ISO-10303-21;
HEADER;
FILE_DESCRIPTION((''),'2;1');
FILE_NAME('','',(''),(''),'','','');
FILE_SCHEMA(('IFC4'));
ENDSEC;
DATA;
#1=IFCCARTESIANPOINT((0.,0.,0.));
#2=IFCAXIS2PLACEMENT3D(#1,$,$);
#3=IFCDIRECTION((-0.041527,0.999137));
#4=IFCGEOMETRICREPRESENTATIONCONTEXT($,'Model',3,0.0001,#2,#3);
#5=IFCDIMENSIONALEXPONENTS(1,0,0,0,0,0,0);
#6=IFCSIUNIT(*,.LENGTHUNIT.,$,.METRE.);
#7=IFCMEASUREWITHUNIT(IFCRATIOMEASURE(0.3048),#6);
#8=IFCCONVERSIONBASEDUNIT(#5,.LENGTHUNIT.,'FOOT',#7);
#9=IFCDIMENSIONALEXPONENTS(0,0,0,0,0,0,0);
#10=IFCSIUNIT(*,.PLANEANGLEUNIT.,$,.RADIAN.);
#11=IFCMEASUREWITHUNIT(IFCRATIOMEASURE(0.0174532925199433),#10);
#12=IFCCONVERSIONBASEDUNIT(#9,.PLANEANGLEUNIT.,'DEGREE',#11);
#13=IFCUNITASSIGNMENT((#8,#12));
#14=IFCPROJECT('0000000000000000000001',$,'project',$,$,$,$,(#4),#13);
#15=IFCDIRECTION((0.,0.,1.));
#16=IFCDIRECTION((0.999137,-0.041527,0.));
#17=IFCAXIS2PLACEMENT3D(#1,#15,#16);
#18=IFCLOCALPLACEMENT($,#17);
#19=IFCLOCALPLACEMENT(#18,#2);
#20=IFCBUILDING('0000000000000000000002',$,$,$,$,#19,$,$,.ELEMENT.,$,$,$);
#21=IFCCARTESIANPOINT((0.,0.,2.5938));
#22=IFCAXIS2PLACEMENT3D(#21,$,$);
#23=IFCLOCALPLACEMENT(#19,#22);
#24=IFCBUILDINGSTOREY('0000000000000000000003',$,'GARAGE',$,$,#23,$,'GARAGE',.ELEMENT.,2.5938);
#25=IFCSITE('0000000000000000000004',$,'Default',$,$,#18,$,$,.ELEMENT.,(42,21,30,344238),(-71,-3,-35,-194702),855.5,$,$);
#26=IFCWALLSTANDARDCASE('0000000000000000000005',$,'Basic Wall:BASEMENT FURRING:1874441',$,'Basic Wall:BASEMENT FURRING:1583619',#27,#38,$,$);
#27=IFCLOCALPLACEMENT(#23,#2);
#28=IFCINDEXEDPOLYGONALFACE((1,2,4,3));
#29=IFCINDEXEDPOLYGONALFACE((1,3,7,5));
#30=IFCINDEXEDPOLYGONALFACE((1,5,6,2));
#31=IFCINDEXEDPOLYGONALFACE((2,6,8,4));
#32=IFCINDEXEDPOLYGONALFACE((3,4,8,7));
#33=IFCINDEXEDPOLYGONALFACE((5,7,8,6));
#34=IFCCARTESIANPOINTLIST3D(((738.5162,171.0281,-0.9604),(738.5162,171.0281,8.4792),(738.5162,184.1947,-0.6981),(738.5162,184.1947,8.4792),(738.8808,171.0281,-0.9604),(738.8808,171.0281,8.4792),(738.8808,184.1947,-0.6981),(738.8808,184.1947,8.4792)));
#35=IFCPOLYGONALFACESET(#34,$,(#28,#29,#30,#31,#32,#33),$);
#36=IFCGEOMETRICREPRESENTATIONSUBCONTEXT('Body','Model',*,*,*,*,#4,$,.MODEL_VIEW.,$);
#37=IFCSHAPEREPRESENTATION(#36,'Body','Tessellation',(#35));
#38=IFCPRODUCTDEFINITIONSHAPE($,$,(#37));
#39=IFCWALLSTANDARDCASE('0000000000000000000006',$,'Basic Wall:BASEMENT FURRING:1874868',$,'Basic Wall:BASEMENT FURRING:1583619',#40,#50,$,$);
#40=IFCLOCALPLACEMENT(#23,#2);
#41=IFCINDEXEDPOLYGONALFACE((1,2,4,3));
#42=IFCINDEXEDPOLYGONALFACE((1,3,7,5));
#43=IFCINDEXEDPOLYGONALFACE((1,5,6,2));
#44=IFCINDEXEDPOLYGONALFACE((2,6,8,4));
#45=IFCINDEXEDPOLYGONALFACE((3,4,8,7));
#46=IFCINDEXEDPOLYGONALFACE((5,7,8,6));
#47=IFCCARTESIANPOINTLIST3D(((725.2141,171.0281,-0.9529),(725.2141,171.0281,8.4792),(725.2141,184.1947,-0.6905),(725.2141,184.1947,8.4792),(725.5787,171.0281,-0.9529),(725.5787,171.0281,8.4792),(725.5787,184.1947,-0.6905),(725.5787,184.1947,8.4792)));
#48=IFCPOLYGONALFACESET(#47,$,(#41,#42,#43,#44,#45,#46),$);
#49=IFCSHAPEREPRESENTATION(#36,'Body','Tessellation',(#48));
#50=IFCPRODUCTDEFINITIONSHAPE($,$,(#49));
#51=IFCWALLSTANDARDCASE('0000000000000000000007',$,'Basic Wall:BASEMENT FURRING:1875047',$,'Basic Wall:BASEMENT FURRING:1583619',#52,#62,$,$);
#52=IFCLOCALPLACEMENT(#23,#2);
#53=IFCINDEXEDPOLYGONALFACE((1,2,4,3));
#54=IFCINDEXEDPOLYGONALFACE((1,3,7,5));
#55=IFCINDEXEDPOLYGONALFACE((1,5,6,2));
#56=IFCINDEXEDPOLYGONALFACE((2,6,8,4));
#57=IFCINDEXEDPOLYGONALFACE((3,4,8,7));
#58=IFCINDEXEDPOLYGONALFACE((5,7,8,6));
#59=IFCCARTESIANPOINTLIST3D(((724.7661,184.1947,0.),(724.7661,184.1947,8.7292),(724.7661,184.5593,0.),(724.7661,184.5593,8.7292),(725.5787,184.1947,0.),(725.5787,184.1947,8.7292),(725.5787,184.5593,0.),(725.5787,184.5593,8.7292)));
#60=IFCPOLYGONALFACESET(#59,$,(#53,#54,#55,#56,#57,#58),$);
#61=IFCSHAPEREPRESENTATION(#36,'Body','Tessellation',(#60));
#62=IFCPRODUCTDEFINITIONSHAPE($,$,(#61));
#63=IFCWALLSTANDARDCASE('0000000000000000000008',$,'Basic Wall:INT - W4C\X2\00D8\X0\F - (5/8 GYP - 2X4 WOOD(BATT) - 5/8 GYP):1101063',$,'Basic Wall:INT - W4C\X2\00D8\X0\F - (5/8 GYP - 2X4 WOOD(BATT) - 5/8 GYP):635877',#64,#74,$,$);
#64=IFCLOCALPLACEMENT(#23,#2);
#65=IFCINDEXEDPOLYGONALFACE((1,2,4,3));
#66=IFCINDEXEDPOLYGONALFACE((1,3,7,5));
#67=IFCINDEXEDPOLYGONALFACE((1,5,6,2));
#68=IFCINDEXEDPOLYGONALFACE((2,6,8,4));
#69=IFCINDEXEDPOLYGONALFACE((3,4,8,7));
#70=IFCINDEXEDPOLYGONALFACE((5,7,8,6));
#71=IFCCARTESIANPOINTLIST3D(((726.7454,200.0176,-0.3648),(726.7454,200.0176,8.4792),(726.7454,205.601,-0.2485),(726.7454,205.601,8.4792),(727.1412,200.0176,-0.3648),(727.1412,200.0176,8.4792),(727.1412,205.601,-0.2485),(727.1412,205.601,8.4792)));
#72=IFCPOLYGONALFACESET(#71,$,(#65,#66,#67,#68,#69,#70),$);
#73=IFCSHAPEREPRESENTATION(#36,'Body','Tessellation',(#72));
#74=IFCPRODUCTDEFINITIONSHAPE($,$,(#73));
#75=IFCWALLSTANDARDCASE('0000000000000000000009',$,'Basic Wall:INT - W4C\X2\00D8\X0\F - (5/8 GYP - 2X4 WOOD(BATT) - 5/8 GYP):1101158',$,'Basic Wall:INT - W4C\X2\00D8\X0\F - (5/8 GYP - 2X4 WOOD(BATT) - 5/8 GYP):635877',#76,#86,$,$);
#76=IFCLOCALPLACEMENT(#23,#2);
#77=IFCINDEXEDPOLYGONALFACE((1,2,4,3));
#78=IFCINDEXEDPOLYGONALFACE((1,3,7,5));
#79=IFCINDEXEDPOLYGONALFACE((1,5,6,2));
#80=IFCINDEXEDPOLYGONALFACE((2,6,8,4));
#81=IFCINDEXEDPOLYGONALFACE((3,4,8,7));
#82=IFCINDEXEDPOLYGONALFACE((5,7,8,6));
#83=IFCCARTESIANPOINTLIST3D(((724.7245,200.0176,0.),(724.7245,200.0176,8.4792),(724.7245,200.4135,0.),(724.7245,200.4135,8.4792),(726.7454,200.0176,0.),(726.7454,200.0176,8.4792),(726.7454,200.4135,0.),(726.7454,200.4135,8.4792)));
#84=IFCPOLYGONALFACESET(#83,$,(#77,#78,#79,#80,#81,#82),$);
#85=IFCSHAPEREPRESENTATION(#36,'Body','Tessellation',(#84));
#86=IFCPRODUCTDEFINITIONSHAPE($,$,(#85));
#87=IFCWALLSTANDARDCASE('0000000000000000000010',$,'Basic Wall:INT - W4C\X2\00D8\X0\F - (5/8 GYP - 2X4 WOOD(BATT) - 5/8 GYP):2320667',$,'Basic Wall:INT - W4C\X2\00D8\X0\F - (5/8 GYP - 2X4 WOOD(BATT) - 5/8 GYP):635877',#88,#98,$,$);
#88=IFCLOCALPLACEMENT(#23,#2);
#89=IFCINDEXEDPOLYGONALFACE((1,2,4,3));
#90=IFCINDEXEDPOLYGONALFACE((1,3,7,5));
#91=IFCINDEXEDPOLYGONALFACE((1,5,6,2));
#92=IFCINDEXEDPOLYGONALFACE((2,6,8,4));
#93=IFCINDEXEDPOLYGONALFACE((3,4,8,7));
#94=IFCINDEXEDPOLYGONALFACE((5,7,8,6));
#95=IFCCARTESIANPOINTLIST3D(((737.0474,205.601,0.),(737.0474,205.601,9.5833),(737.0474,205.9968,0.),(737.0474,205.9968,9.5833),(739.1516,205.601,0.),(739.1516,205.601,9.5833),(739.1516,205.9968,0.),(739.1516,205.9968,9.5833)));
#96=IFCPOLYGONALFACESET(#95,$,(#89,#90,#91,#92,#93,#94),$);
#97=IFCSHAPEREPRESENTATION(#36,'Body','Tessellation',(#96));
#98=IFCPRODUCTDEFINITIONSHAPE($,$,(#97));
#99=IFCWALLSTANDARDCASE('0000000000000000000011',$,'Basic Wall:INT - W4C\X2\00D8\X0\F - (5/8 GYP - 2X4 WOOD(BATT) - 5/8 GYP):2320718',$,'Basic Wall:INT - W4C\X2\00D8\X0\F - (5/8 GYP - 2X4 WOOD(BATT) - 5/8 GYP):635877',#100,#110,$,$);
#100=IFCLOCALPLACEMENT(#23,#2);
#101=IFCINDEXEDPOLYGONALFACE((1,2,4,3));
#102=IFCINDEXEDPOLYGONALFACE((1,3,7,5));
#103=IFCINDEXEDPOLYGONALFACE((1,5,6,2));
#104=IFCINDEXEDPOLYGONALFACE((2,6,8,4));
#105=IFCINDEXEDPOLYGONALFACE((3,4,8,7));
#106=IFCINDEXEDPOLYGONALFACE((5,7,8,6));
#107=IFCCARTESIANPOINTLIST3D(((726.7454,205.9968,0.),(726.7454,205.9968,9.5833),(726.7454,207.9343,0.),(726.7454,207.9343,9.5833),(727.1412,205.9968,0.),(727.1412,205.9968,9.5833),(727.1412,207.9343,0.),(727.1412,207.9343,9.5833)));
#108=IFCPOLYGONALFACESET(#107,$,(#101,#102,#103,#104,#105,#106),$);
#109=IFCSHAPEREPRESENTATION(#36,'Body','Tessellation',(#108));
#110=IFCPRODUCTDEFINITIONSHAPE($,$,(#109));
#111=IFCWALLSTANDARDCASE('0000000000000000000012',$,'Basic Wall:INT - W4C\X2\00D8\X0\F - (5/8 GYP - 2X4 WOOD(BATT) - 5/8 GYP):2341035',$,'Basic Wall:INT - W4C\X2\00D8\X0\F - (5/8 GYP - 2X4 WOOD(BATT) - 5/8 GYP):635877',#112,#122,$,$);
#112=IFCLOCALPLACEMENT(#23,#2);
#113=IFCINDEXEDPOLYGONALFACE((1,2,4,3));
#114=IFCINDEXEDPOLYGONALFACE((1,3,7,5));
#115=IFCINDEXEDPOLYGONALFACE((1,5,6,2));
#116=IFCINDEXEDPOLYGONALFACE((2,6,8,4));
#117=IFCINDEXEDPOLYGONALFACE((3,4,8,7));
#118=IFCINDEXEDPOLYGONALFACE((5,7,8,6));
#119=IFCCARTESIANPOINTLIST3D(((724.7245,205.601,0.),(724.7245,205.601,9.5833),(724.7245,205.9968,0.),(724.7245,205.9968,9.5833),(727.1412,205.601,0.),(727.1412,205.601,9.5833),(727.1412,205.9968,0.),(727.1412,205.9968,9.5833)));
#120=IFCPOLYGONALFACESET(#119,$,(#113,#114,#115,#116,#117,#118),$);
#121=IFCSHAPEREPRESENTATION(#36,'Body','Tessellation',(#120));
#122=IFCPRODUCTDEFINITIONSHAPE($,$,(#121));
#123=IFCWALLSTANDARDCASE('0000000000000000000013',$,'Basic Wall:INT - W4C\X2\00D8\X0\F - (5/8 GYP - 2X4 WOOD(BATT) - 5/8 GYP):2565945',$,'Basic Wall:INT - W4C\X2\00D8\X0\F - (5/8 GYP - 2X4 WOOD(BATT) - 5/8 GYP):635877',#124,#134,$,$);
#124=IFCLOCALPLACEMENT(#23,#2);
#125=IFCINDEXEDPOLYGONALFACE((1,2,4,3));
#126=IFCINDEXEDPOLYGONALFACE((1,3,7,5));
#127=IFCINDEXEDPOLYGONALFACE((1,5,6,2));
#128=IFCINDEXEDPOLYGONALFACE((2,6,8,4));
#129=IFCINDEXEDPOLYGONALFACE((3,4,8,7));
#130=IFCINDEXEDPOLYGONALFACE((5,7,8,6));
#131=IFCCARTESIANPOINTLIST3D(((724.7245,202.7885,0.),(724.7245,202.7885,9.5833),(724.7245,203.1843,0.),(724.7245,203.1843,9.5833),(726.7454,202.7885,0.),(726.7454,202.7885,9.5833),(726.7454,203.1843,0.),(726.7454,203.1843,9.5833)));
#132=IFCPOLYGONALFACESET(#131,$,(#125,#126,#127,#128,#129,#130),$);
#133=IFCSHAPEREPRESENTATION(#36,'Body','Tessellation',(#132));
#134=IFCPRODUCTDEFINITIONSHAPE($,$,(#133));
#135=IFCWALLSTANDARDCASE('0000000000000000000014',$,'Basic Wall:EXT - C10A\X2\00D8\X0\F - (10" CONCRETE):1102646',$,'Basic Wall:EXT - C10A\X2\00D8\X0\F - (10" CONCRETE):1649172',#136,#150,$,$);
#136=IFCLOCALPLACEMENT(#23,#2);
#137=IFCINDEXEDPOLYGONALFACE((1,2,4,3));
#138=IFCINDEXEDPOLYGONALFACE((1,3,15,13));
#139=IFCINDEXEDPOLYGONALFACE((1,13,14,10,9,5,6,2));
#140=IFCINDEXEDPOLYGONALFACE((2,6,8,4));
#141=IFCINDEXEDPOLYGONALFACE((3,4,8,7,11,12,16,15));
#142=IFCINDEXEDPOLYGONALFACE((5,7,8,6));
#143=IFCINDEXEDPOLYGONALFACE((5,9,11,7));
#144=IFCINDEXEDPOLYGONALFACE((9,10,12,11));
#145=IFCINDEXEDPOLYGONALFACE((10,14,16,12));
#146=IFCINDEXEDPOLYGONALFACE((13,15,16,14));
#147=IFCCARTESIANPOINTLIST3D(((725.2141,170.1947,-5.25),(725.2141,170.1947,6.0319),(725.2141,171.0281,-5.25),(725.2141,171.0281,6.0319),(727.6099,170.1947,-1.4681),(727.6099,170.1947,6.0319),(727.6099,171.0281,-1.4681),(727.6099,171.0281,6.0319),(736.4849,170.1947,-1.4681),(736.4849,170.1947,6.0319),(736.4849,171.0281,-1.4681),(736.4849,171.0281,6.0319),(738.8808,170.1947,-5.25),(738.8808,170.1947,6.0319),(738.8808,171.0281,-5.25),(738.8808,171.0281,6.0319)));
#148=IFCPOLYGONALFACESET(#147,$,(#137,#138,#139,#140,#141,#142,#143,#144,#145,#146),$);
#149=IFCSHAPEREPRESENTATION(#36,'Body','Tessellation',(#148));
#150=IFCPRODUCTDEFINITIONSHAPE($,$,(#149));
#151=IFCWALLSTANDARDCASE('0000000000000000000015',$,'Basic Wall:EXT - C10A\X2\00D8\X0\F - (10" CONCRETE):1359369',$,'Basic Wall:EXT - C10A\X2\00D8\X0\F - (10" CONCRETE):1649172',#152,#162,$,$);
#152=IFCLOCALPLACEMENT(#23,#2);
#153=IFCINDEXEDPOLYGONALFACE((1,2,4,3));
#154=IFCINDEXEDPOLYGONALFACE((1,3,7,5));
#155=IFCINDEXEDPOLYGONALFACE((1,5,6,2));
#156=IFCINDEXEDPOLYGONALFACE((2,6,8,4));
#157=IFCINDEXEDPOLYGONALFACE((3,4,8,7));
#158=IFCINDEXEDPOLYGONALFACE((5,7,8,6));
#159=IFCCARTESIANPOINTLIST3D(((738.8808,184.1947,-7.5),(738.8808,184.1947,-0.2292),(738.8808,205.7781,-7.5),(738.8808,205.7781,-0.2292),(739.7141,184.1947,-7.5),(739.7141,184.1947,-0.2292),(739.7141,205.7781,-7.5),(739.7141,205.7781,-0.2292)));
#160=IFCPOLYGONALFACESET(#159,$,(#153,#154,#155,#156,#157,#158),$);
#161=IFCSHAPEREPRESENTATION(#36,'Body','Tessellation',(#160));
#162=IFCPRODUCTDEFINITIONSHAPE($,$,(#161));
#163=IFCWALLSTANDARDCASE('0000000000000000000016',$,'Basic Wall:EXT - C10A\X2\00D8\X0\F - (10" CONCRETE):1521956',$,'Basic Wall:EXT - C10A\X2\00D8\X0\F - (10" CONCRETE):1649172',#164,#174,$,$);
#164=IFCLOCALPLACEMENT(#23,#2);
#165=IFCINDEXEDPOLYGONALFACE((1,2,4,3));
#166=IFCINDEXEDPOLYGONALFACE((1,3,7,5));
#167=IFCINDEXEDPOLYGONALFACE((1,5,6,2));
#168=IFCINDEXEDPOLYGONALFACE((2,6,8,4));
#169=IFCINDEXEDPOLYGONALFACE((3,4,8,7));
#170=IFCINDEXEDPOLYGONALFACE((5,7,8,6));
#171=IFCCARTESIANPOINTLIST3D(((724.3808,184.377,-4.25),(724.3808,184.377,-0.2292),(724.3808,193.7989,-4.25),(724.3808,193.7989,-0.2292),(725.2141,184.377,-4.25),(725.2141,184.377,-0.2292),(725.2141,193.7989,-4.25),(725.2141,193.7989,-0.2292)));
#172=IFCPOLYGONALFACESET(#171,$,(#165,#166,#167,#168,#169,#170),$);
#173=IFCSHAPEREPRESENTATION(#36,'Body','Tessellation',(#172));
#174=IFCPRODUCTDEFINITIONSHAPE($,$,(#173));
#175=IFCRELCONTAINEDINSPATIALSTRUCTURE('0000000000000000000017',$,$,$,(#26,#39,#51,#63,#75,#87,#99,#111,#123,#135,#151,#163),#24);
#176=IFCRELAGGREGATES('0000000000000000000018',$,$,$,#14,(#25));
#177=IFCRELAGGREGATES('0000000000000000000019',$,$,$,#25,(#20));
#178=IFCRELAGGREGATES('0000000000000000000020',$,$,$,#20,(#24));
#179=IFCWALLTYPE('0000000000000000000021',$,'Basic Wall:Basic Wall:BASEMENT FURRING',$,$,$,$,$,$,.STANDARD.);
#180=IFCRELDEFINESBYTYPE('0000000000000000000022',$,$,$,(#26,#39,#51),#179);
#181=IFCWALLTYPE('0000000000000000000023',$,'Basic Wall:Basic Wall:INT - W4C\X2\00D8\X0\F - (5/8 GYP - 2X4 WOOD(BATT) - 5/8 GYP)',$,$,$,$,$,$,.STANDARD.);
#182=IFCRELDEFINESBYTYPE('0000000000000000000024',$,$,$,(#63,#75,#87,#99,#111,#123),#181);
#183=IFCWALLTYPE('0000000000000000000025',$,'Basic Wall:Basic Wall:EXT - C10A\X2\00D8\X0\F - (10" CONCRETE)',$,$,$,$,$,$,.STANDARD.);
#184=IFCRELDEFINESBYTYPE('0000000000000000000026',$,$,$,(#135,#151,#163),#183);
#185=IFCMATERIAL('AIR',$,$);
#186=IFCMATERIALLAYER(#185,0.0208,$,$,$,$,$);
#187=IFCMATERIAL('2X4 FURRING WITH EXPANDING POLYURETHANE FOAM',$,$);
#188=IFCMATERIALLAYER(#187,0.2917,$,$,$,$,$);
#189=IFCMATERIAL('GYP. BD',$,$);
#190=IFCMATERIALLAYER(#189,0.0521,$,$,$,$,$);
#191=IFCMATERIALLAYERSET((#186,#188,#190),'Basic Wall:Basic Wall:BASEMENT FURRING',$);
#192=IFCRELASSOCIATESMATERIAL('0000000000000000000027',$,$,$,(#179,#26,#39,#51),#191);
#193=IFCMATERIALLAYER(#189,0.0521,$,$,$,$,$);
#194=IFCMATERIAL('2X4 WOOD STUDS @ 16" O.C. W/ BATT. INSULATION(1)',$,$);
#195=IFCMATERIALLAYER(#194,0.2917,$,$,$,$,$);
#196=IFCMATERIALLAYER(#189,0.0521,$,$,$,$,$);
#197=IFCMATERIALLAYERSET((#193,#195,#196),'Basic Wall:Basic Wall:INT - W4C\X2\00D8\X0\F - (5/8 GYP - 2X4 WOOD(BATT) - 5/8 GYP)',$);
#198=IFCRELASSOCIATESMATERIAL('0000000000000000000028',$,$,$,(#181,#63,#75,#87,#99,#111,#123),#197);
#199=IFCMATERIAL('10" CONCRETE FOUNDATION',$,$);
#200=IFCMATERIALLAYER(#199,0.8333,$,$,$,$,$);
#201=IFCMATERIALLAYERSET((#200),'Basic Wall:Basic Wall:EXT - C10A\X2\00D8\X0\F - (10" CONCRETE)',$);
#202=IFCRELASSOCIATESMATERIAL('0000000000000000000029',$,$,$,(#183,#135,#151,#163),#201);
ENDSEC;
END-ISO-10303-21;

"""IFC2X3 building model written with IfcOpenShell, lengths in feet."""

from ifc_helpers import new_model, entity, si_unit, converted_unit, direction, frame, frame_2d, origin, place, context, subcontext, project, spatial, rectangle, extrude, clip, halfspace, material, layer, layer_set, layer_usage, type_object, element, save


model = new_model("IFC2X3")

# Units and contexts
model_context = context("Model", 3, precision=0.0001, world=origin(), true_north=direction((-0.041527, 0.999137)))
body_context = subcontext(model_context, "Body", "Model", "MODEL_VIEW")
ifc_project = project(units=[converted_unit("LENGTHUNIT", "FOOT", entity("IfcRatioMeasure", 0.3048), si_unit("LENGTHUNIT", "METRE"), dimensions=[1, 0, 0, 0, 0, 0, 0]), converted_unit("PLANEANGLEUNIT", "DEGREE", entity("IfcRatioMeasure", 0.0174532925199433), si_unit("PLANEANGLEUNIT", "RADIAN"), dimensions=[0, 0, 0, 0, 0, 0, 0])], contexts=[model_context])

# Site, building, storey
site_placement = place(None, frame((0.0, 0.0, 0.0), z_axis=(0.0, 0.0, 1.0), x_axis=(0.999137, -0.041527, 0.0)))
site = spatial("IfcSite", under=ifc_project, at=site_placement, Name="Default", CompositionType="ELEMENT", RefLatitude=(42, 21, 30, 344238), RefLongitude=(-71, -3, -35, -194702), RefElevation=855.5)
building_placement = place(site_placement, origin())
building = spatial("IfcBuilding", under=site, at=building_placement, CompositionType="ELEMENT")
storey_placement = place(building_placement, frame((0.0, 0.0, 2.5938)))
storey = spatial("IfcBuildingStorey", under=building, at=storey_placement, Name="GARAGE", LongName="GARAGE", CompositionType="ELEMENT", Elevation=2.5938)

# Shared definitions
ifc_material_1 = material(Name="AIR")
ifc_layer_1 = layer(ifc_material_1, 0.0208)
ifc_material_2 = material(Name="2X4 FURRING WITH EXPANDING POLYURETHANE FOAM")
ifc_layer_2 = layer(ifc_material_2, 0.2917)
ifc_material_3 = material(Name="GYP. BD")
ifc_layer_3 = layer(ifc_material_3, 0.0521)
ifc_layer_set_1 = layer_set([ifc_layer_1, ifc_layer_2, ifc_layer_3], Name="Basic Wall:Basic Wall:BASEMENT FURRING")
wall_type_1 = type_object("IfcWallType", Name="Basic Wall:Basic Wall:BASEMENT FURRING", PredefinedType="STANDARD", material=ifc_layer_set_1)

# Walls
ifc_layer_usage_1 = layer_usage(ifc_layer_set_1, "AXIS2", "NEGATIVE", 0.1823)
wall_1_placement = place(storey_placement, frame((738.6985, 184.1947, -0.9604), z_axis=(0.0, 0.0, 1.0), x_axis=(0.0, -1.0, 0.0)))
element("IfcWallStandardCase", 1, at=wall_1_placement, inside=storey, type_object=wall_type_1, material=ifc_layer_usage_1, Name="Basic Wall:BASEMENT FURRING:1874441", ObjectType="Basic Wall:BASEMENT FURRING:1583619", context=body_context, shape_type="Clipping", body=[
    clip(extrude(rectangle(XDim=13.1667, YDim=0.3646, at=frame_2d((6.5833, 0.0), x_axis=(-1.0, 0.0))), origin(), (0.0, 0.0, 1.0), 9.4396), halfspace(frame((13.1667, -0.1823, 0.0), z_axis=(-0.019923, 0.0, -0.999802), x_axis=(0.0, 1.0, 0.0)), False)),
])
ifc_layer_usage_2 = layer_usage(ifc_layer_set_1, "AXIS2", "NEGATIVE", 0.1823)
wall_2_placement = place(storey_placement, frame((725.3964, 171.0281, -0.9529), z_axis=(0.0, 0.0, 1.0), x_axis=(0.0, 1.0, 0.0)))
element("IfcWallStandardCase", 2, at=wall_2_placement, inside=storey, type_object=wall_type_1, material=ifc_layer_usage_2, Name="Basic Wall:BASEMENT FURRING:1874868", ObjectType="Basic Wall:BASEMENT FURRING:1583619", context=body_context, shape_type="Clipping", body=[
    clip(extrude(rectangle(XDim=13.1667, YDim=0.3646, at=frame_2d((6.5833, 0.0), x_axis=(-1.0, 0.0))), origin(), (0.0, 0.0, 1.0), 9.432), halfspace(frame((13.1667, -0.1823, 0.2624), z_axis=(0.019923, 0.0, -0.999802), x_axis=(0.0, 1.0, 0.0)), False)),
])
ifc_layer_usage_3 = layer_usage(ifc_layer_set_1, "AXIS2", "NEGATIVE", 0.1823)
wall_3_placement = place(storey_placement, frame((725.5787, 184.377, 0.0), z_axis=(0.0, 0.0, 1.0), x_axis=(-1.0, 0.0, 0.0)))
element("IfcWallStandardCase", 3, at=wall_3_placement, inside=storey, type_object=wall_type_1, material=ifc_layer_usage_3, Name="Basic Wall:BASEMENT FURRING:1875047", ObjectType="Basic Wall:BASEMENT FURRING:1583619", context=body_context, shape_type="SweptSolid", body=[
    extrude(rectangle(XDim=0.8125, YDim=0.3646, at=frame_2d((0.4063, 0.0), x_axis=(-1.0, 0.0))), origin(), (0.0, 0.0, 1.0), 8.7292),
])
ifc_layer_4 = layer(ifc_material_3, 0.0521)
ifc_material_4 = material(Name="2X4 WOOD STUDS @ 16\" O.C. W/ BATT. INSULATION(1)")
ifc_layer_5 = layer(ifc_material_4, 0.2917)
ifc_layer_6 = layer(ifc_material_3, 0.0521)
ifc_layer_set_2 = layer_set([ifc_layer_4, ifc_layer_5, ifc_layer_6], Name="Basic Wall:Basic Wall:INT - W4CØF - (5/8 GYP - 2X4 WOOD(BATT) - 5/8 GYP)")
ifc_layer_usage_4 = layer_usage(ifc_layer_set_2, "AXIS2", "NEGATIVE", 0.1979)
wall_type_2 = type_object("IfcWallType", Name="Basic Wall:Basic Wall:INT - W4CØF - (5/8 GYP - 2X4 WOOD(BATT) - 5/8 GYP)", PredefinedType="STANDARD", material=ifc_layer_set_2)
wall_4_placement = place(storey_placement, frame((726.9433, 205.601, -0.3648), z_axis=(0.0, 0.0, 1.0), x_axis=(0.0, -1.0, 0.0)))
element("IfcWallStandardCase", 4, at=wall_4_placement, inside=storey, type_object=wall_type_2, material=ifc_layer_usage_4, Name="Basic Wall:INT - W4CØF - (5/8 GYP - 2X4 WOOD(BATT) - 5/8 GYP):1101063", ObjectType="Basic Wall:INT - W4CØF - (5/8 GYP - 2X4 WOOD(BATT) - 5/8 GYP):635877", context=body_context, shape_type="Clipping", body=[
    clip(extrude(rectangle(XDim=5.5833, YDim=0.3958, at=frame_2d((2.7917, 0.0), x_axis=(-1.0, 0.0))), origin(), (0.0, 0.0, 1.0), 8.844), halfspace(frame((5.5833, -0.1979, 0.0), z_axis=(-0.020829, 0.0, -0.999783), x_axis=(0.0, 1.0, 0.0)), False)),
])
ifc_layer_usage_5 = layer_usage(ifc_layer_set_2, "AXIS2", "NEGATIVE", 0.1979)
wall_5_placement = place(storey_placement, frame((724.7245, 200.2156, 0.0)))
element("IfcWallStandardCase", 5, at=wall_5_placement, inside=storey, type_object=wall_type_2, material=ifc_layer_usage_5, Name="Basic Wall:INT - W4CØF - (5/8 GYP - 2X4 WOOD(BATT) - 5/8 GYP):1101158", ObjectType="Basic Wall:INT - W4CØF - (5/8 GYP - 2X4 WOOD(BATT) - 5/8 GYP):635877", context=body_context, shape_type="SweptSolid", body=[
    extrude(rectangle(XDim=2.0208, YDim=0.3958, at=frame_2d((1.0104, 0.0), x_axis=(-1.0, 0.0))), origin(), (0.0, 0.0, 1.0), 8.4792),
])

# Walls
ifc_layer_usage_6 = layer_usage(ifc_layer_set_2, "AXIS2", "NEGATIVE", 0.1979)
wall_6_placement = place(storey_placement, frame((737.0474, 205.7989, 0.0)))
element("IfcWallStandardCase", 6, at=wall_6_placement, inside=storey, type_object=wall_type_2, material=ifc_layer_usage_6, Name="Basic Wall:INT - W4CØF - (5/8 GYP - 2X4 WOOD(BATT) - 5/8 GYP):2320667", ObjectType="Basic Wall:INT - W4CØF - (5/8 GYP - 2X4 WOOD(BATT) - 5/8 GYP):635877", context=body_context, shape_type="SweptSolid", body=[
    extrude(rectangle(XDim=2.1042, YDim=0.3958, at=frame_2d((1.0521, 0.0), x_axis=(-1.0, 0.0))), origin(), (0.0, 0.0, 1.0), 9.5833),
])
ifc_layer_usage_7 = layer_usage(ifc_layer_set_2, "AXIS2", "NEGATIVE", 0.1979)
wall_7_placement = place(storey_placement, frame((726.9433, 207.9343, 0.0), z_axis=(0.0, 0.0, 1.0), x_axis=(0.0, -1.0, 0.0)))
element("IfcWallStandardCase", 7, at=wall_7_placement, inside=storey, type_object=wall_type_2, material=ifc_layer_usage_7, Name="Basic Wall:INT - W4CØF - (5/8 GYP - 2X4 WOOD(BATT) - 5/8 GYP):2320718", ObjectType="Basic Wall:INT - W4CØF - (5/8 GYP - 2X4 WOOD(BATT) - 5/8 GYP):635877", context=body_context, shape_type="SweptSolid", body=[
    extrude(rectangle(XDim=1.9375, YDim=0.3958, at=frame_2d((0.9688, 0.0), x_axis=(-1.0, 0.0))), origin(), (0.0, 0.0, 1.0), 9.5833),
])

# Walls
ifc_layer_usage_8 = layer_usage(ifc_layer_set_2, "AXIS2", "NEGATIVE", 0.1979)
wall_8_placement = place(storey_placement, frame((724.7245, 205.7989, 0.0)))
element("IfcWallStandardCase", 8, at=wall_8_placement, inside=storey, type_object=wall_type_2, material=ifc_layer_usage_8, Name="Basic Wall:INT - W4CØF - (5/8 GYP - 2X4 WOOD(BATT) - 5/8 GYP):2341035", ObjectType="Basic Wall:INT - W4CØF - (5/8 GYP - 2X4 WOOD(BATT) - 5/8 GYP):635877", context=body_context, shape_type="SweptSolid", body=[
    extrude(rectangle(XDim=2.4167, YDim=0.3958, at=frame_2d((1.2083, 0.0), x_axis=(-1.0, 0.0))), origin(), (0.0, 0.0, 1.0), 9.5833),
])
ifc_layer_usage_9 = layer_usage(ifc_layer_set_2, "AXIS2", "NEGATIVE", 0.1979)
wall_9_placement = place(storey_placement, frame((724.7245, 202.9864, 0.0)))
element("IfcWallStandardCase", 9, at=wall_9_placement, inside=storey, type_object=wall_type_2, material=ifc_layer_usage_9, Name="Basic Wall:INT - W4CØF - (5/8 GYP - 2X4 WOOD(BATT) - 5/8 GYP):2565945", ObjectType="Basic Wall:INT - W4CØF - (5/8 GYP - 2X4 WOOD(BATT) - 5/8 GYP):635877", context=body_context, shape_type="SweptSolid", body=[
    extrude(rectangle(XDim=2.0208, YDim=0.3958, at=frame_2d((1.0104, 0.0), x_axis=(-1.0, 0.0))), origin(), (0.0, 0.0, 1.0), 9.5833),
])

# Wall, opening
ifc_material_5 = material(Name="10\" CONCRETE FOUNDATION")
ifc_layer_7 = layer(ifc_material_5, 0.8333)
ifc_layer_set_3 = layer_set([ifc_layer_7], Name="Basic Wall:Basic Wall:EXT - C10AØF - (10\" CONCRETE)")
ifc_layer_usage_10 = layer_usage(ifc_layer_set_3, "AXIS2", "NEGATIVE", 0.4167)
wall_type_3 = type_object("IfcWallType", Name="Basic Wall:Basic Wall:EXT - C10AØF - (10\" CONCRETE)", PredefinedType="STANDARD", material=ifc_layer_set_3)
wall_10_placement = place(storey_placement, frame((738.8808, 170.6114, -5.25), z_axis=(0.0, 0.0, 1.0), x_axis=(-1.0, 0.0, 0.0)))
wall_10 = element("IfcWallStandardCase", 10, at=wall_10_placement, inside=storey, type_object=wall_type_3, material=ifc_layer_usage_10, Name="Basic Wall:EXT - C10AØF - (10\" CONCRETE):1102646", ObjectType="Basic Wall:EXT - C10AØF - (10\" CONCRETE):1649172", context=body_context, shape_type="SweptSolid", body=[
    extrude(rectangle(XDim=13.6667, YDim=0.8333, at=frame_2d((6.8333, 0.0), x_axis=(-1.0, 0.0))), origin(), (0.0, 0.0, 1.0), 11.2819),
])
opening_1_placement = place(wall_10_placement, origin())
element("IfcOpeningElement", 11, at=opening_1_placement, cuts=wall_10, ObjectType="Opening", context=body_context, shape_type="SweptSolid", body=[
    extrude(rectangle(XDim=7.5, YDim=8.875, at=frame_2d((0.0, 0.0), x_axis=(1.0, 0.0))), frame((6.8333, -0.4167, 7.5319), z_axis=(0.0, 1.0, 0.0), x_axis=(0.0, 0.0, -1.0)), (0.0, 0.0, 1.0), 0.8333),
])

# Walls
ifc_layer_usage_11 = layer_usage(ifc_layer_set_3, "AXIS2", "NEGATIVE", 0.4167)
wall_11_placement = place(storey_placement, frame((739.2974, 205.7781, -7.5), z_axis=(0.0, 0.0, 1.0), x_axis=(0.0, -1.0, 0.0)))
element("IfcWallStandardCase", 12, at=wall_11_placement, inside=storey, type_object=wall_type_3, material=ifc_layer_usage_11, Name="Basic Wall:EXT - C10AØF - (10\" CONCRETE):1359369", ObjectType="Basic Wall:EXT - C10AØF - (10\" CONCRETE):1649172", context=body_context, shape_type="SweptSolid", body=[
    extrude(rectangle(XDim=21.5833, YDim=0.8333, at=frame_2d((10.7917, 0.0), x_axis=(-1.0, 0.0))), origin(), (0.0, 0.0, 1.0), 7.2708),
])
ifc_layer_usage_12 = layer_usage(ifc_layer_set_3, "AXIS2", "NEGATIVE", 0.4167)
wall_12_placement = place(storey_placement, frame((724.7974, 184.377, -4.25), z_axis=(0.0, 0.0, 1.0), x_axis=(0.0, 1.0, 0.0)))
element("IfcWallStandardCase", 13, at=wall_12_placement, inside=storey, type_object=wall_type_3, material=ifc_layer_usage_12, Name="Basic Wall:EXT - C10AØF - (10\" CONCRETE):1521956", ObjectType="Basic Wall:EXT - C10AØF - (10\" CONCRETE):1649172", context=body_context, shape_type="SweptSolid", body=[
    extrude(rectangle(XDim=9.4219, YDim=0.8333, at=frame_2d((4.7109, 0.0), x_axis=(-1.0, 0.0))), origin(), (0.0, 0.0, 1.0), 4.0208),
])

save(model, "model.ifc")
